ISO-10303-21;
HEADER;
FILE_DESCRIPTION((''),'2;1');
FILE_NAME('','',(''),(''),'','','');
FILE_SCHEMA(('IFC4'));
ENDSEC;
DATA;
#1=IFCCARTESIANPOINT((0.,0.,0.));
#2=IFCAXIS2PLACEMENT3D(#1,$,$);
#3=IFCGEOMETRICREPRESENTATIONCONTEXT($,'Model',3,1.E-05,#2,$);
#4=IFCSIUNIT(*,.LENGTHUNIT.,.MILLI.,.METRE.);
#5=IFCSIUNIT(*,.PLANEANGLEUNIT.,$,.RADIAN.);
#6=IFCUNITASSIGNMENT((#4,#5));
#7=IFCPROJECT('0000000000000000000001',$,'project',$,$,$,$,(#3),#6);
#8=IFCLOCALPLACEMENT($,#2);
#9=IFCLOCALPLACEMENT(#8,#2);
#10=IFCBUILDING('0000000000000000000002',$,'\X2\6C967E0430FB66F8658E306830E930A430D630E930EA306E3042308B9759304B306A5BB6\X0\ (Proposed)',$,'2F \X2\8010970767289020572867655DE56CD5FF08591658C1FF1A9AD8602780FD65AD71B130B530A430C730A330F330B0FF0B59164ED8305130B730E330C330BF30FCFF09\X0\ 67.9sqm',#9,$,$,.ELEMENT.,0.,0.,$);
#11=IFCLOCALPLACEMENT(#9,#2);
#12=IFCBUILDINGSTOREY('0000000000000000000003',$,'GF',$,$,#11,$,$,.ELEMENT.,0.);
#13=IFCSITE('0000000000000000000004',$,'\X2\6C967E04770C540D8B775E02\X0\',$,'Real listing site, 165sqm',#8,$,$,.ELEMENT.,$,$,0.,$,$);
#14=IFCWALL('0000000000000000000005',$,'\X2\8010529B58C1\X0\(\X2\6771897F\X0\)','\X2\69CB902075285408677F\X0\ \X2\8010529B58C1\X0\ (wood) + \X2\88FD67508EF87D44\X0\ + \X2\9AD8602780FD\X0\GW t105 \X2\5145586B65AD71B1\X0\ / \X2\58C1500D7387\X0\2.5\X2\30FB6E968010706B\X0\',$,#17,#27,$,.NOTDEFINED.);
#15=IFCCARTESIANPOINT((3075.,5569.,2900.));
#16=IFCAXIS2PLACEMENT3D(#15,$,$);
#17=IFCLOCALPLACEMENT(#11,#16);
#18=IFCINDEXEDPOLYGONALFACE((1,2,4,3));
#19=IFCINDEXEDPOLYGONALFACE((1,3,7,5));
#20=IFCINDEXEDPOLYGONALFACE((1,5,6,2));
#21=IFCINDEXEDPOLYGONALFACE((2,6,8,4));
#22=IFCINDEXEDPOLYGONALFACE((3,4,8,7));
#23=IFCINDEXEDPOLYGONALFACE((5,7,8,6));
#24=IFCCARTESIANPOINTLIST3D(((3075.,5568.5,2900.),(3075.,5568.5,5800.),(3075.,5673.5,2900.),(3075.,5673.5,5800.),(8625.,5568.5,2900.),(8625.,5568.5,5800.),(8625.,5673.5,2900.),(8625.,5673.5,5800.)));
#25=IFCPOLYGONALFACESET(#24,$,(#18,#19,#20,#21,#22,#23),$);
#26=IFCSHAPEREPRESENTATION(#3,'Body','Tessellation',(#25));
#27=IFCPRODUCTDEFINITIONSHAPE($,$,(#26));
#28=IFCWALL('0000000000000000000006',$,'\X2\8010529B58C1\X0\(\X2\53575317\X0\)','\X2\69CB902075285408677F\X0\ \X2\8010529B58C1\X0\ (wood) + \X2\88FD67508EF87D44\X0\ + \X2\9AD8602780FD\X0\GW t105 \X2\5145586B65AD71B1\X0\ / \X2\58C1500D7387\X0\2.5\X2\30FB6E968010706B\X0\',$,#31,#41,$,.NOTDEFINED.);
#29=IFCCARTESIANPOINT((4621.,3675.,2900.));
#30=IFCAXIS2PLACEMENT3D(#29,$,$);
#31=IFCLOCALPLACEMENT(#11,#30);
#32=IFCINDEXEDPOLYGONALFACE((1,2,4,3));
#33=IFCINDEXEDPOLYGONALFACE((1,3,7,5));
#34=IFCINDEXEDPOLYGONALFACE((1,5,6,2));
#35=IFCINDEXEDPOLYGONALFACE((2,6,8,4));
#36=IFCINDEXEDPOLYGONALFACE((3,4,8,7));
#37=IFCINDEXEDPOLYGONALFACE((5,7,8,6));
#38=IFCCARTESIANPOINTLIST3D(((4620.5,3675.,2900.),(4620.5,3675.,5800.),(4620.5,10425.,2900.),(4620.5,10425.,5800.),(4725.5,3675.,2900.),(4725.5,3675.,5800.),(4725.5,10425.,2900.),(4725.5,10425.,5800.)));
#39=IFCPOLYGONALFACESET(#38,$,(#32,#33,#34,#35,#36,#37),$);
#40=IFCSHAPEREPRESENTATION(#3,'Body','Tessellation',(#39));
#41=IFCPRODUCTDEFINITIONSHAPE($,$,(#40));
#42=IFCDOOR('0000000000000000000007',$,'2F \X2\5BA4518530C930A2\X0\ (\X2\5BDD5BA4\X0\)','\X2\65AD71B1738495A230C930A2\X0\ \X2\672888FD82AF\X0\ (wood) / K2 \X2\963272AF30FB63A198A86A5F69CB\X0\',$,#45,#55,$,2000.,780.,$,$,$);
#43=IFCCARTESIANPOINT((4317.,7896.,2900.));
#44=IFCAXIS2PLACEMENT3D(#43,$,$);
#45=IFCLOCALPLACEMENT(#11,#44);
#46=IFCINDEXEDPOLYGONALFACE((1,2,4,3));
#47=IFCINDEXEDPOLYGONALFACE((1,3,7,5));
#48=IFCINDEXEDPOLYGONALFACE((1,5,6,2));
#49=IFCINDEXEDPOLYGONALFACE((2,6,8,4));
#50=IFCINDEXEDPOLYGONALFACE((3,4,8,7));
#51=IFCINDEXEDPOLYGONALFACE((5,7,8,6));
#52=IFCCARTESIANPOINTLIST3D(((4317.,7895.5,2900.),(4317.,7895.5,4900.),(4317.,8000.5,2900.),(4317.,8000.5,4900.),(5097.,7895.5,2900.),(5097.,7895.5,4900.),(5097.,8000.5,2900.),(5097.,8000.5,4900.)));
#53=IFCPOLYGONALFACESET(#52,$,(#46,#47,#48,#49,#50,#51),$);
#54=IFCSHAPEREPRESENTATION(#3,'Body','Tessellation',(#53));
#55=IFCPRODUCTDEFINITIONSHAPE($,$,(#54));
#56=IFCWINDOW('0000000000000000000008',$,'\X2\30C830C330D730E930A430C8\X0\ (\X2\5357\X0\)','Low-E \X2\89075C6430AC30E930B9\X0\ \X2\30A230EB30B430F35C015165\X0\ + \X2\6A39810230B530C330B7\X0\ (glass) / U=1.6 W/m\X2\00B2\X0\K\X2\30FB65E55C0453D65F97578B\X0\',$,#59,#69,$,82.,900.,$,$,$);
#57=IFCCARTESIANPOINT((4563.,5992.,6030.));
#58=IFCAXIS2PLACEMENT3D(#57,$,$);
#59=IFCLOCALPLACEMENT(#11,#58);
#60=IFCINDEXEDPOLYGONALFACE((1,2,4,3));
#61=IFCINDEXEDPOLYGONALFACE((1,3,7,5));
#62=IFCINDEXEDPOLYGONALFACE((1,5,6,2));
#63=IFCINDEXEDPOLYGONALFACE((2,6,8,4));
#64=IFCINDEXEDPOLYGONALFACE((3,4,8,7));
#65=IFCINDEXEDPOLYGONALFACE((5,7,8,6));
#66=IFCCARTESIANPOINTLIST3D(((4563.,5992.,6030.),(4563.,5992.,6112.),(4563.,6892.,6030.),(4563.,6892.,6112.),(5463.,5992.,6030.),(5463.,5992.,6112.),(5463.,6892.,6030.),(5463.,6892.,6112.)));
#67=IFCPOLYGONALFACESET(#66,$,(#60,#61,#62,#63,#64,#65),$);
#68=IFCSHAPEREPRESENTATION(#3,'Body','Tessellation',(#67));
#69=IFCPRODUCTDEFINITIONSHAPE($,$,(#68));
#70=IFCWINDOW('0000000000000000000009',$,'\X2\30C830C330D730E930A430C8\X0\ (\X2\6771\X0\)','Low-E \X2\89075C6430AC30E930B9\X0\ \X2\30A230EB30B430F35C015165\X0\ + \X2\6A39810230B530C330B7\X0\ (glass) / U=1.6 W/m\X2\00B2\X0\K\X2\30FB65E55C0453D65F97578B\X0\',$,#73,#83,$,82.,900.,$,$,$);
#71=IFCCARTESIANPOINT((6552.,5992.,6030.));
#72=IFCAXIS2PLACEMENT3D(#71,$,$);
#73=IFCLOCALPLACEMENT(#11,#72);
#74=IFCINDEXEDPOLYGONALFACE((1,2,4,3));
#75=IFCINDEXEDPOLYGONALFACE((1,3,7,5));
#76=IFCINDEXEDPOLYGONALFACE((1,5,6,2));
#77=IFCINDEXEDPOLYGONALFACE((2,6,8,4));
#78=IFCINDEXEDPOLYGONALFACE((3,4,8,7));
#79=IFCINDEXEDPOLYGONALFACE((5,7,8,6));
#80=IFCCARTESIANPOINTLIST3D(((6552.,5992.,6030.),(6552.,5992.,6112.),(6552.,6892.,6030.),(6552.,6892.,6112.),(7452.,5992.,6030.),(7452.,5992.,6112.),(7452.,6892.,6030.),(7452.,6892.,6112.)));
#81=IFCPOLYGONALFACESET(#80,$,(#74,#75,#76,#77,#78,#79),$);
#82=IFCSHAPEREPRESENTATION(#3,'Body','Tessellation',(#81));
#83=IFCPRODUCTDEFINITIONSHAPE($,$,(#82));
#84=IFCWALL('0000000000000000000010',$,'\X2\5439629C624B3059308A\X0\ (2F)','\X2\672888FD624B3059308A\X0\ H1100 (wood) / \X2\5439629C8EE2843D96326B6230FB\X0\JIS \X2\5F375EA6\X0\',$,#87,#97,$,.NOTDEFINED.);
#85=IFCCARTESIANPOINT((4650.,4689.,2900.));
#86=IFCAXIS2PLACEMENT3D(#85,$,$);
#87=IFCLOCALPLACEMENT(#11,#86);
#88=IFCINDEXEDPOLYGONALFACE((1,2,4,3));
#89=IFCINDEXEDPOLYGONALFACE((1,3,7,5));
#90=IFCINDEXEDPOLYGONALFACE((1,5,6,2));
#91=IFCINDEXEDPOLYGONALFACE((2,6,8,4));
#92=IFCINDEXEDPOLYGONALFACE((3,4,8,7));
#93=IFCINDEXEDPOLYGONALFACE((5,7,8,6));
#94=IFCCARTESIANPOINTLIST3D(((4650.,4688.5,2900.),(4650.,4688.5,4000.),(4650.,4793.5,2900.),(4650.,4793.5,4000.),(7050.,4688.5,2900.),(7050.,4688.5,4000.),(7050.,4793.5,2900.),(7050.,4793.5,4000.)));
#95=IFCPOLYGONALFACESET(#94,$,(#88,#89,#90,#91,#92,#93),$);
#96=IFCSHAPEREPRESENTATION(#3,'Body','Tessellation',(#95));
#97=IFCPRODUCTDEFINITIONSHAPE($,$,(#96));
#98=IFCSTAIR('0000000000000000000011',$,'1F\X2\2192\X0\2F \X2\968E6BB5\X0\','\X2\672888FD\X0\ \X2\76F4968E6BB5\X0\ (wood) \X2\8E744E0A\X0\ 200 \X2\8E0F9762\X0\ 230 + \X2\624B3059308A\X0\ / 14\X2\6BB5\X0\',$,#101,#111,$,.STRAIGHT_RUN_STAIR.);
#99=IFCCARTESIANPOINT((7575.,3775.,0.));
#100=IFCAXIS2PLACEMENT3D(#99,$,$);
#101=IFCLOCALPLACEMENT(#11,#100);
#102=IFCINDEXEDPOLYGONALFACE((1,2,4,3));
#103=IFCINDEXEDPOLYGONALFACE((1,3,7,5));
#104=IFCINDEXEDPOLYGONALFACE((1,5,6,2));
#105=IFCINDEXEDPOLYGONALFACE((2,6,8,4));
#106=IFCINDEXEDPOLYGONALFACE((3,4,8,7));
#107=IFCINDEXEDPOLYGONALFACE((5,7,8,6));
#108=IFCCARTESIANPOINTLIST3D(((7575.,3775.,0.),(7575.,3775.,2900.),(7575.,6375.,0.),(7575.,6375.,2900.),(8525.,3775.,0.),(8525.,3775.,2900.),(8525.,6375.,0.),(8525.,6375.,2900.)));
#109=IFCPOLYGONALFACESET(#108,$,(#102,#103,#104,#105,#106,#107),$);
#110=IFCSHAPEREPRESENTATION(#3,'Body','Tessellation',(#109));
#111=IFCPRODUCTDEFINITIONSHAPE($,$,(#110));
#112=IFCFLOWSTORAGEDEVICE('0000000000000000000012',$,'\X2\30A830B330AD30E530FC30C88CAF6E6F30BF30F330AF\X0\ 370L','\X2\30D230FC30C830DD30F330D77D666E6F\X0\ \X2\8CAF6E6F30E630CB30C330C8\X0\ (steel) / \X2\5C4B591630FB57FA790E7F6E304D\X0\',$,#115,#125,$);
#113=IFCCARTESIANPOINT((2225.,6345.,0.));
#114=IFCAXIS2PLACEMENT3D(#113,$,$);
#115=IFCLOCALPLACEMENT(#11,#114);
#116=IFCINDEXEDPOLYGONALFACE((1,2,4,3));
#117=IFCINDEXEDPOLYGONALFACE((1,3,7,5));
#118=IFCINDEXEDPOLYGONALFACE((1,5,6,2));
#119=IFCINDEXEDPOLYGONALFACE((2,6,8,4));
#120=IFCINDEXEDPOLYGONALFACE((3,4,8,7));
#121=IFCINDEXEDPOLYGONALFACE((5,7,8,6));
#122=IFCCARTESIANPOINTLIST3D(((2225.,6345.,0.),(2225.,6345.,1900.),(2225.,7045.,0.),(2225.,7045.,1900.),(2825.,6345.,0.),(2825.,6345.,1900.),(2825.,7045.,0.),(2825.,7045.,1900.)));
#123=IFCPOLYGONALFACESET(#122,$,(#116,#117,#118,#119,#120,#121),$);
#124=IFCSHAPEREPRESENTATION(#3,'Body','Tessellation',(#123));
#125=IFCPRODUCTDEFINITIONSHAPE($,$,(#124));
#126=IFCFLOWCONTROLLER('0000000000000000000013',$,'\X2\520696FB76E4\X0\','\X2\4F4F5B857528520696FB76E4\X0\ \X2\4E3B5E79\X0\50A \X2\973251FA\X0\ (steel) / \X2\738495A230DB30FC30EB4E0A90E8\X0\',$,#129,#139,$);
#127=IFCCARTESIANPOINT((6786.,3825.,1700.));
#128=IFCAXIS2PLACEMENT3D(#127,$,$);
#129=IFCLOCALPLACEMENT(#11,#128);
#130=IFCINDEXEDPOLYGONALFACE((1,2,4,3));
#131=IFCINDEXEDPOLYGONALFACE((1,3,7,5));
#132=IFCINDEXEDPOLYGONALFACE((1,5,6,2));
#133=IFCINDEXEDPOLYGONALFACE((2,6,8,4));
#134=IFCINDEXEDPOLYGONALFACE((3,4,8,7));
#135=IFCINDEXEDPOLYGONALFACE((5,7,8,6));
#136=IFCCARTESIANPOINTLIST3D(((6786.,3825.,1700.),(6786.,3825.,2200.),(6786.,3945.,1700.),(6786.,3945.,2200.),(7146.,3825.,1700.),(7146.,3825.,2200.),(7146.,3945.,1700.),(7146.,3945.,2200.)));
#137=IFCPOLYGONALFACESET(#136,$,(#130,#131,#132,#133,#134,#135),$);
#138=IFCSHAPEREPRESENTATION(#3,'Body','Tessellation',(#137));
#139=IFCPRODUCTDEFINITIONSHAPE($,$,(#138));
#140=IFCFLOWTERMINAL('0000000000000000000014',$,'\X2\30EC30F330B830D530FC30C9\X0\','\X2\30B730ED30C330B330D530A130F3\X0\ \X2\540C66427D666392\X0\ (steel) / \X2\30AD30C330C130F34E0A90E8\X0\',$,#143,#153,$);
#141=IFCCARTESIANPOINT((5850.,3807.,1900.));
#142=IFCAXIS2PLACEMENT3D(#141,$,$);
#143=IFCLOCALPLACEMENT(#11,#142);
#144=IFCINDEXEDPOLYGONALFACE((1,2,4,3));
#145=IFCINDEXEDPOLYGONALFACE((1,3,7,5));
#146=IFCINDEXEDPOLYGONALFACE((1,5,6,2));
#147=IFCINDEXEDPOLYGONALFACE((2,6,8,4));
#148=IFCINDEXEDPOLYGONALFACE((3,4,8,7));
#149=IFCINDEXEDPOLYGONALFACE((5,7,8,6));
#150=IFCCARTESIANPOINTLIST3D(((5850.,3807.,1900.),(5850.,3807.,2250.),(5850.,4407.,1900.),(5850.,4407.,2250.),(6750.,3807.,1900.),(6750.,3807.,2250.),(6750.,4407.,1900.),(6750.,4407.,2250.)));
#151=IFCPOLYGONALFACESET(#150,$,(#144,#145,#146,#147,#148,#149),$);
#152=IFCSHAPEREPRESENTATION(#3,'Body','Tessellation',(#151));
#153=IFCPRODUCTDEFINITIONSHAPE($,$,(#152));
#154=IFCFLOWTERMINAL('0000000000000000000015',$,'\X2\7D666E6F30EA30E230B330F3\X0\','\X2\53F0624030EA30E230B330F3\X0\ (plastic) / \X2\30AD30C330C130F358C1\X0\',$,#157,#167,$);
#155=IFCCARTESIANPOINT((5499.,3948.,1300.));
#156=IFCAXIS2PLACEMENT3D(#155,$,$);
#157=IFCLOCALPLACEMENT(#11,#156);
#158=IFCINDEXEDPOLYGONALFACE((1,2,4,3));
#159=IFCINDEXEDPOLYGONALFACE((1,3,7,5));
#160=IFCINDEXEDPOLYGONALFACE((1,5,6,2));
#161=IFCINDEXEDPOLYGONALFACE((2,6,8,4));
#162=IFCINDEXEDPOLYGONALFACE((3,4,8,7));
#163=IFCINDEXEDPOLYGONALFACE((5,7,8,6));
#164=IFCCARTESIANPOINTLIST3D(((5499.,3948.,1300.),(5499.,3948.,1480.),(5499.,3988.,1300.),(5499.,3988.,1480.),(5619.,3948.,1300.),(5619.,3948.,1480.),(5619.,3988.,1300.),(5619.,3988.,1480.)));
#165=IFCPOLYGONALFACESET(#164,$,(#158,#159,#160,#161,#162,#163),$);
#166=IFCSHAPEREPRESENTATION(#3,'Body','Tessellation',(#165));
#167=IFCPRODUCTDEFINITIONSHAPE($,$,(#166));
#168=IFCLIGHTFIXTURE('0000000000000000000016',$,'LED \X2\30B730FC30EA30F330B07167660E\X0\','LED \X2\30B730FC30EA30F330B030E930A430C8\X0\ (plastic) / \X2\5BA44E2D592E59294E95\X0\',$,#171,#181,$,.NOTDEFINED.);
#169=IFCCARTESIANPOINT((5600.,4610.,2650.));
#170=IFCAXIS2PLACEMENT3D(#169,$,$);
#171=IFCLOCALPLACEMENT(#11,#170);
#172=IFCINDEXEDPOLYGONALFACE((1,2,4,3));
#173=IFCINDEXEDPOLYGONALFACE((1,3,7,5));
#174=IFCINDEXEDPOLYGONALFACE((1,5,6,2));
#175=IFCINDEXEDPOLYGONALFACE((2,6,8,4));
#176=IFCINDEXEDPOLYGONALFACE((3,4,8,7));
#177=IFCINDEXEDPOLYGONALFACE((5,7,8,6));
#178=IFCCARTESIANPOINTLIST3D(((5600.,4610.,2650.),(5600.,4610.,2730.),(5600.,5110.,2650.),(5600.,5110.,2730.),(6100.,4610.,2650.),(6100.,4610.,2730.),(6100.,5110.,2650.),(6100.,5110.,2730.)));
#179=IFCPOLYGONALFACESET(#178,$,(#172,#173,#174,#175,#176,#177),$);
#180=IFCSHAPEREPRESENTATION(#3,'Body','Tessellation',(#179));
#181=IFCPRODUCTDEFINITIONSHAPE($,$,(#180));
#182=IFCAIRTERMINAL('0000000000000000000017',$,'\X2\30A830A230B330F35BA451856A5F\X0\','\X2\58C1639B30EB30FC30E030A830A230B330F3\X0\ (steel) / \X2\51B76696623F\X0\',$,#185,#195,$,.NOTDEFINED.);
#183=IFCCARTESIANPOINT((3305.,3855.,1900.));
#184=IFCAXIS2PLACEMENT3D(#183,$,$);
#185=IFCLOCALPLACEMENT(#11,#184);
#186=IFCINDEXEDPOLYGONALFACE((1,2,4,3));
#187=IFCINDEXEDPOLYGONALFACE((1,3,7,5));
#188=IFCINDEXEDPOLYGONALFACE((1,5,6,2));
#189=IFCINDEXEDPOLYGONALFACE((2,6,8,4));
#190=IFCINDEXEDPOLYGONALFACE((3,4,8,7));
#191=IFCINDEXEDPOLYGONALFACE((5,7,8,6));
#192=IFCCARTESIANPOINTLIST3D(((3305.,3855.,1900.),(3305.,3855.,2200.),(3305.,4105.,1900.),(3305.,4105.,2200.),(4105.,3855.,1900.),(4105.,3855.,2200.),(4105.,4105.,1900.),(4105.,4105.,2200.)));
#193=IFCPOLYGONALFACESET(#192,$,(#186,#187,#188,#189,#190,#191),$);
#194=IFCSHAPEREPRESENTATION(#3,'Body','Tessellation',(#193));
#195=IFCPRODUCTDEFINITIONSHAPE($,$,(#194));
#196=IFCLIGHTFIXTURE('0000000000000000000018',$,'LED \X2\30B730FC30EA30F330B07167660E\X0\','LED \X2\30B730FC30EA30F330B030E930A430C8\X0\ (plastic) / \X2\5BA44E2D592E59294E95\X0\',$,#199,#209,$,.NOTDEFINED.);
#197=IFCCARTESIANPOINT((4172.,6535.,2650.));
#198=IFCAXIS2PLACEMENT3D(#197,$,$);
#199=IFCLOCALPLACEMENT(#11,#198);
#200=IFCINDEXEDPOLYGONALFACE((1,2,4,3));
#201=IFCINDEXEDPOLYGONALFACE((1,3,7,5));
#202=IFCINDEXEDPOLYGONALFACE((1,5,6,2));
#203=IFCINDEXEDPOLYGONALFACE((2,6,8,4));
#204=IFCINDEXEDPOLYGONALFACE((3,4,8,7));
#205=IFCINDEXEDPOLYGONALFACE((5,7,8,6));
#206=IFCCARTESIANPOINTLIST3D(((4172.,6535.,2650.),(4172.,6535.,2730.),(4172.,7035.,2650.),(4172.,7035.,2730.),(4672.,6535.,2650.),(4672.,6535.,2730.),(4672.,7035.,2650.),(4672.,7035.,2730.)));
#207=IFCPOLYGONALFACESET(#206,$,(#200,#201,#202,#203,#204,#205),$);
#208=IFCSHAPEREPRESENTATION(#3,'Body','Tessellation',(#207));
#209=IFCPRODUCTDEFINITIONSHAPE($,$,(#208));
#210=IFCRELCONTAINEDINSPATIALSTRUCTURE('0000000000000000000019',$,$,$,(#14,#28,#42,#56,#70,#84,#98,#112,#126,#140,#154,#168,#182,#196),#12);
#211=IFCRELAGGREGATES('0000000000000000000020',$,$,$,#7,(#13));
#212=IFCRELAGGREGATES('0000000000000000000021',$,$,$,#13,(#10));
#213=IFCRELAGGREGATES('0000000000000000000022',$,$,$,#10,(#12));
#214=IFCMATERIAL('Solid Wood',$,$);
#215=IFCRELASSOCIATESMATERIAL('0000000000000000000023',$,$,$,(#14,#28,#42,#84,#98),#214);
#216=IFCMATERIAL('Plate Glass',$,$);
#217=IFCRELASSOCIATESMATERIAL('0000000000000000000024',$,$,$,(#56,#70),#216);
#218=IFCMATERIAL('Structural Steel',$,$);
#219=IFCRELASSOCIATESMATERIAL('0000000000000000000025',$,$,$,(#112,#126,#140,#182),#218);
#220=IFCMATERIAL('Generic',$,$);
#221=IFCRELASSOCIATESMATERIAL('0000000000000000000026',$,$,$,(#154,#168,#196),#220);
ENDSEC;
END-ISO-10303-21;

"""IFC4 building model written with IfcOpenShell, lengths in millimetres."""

from ifc_helpers import new_model, si_unit, frame, frame_2d, origin, place, context, project, spatial, rectangle, extrude, material, element, fill, save


model = new_model("IFC4")

# Units and contexts
model_context = context("Model", 3, precision=1e-05, world=origin())
ifc_project = project(units=[si_unit("LENGTHUNIT", "METRE", prefix="MILLI"), si_unit("PLANEANGLEUNIT", "RADIAN")], contexts=[model_context])

# Site, building, storey
site_placement = place(None, origin())
site = spatial("IfcSite", under=ifc_project, at=site_placement, Name="沖縄県名護市", ObjectType="Real listing site, 165sqm", CompositionType="ELEMENT", RefElevation=0.0)
building_placement = place(site_placement, origin())
building = spatial("IfcBuilding", under=site, at=building_placement, Name="沖縄・書斎とライブラリのある静かな家 (Proposed)", ObjectType="2F 耐震木造在来工法（外壁：高性能断熱サイディング＋外付けシャッター） 67.9sqm", CompositionType="ELEMENT", ElevationOfRefHeight=0.0, ElevationOfTerrain=0.0)
storey_placement = place(building_placement, origin())
storey = spatial("IfcBuildingStorey", under=building, at=storey_placement, Name="GF", CompositionType="ELEMENT", Elevation=0.0)

# Shared definitions
ifc_material_1 = material(Name="Solid Wood")

# Wall
wall_1_placement = place(storey_placement, frame((3075.0, 5569.0, 2900.0)))
element("IfcWall", 1, at=wall_1_placement, inside=storey, material=ifc_material_1, Name="耐力壁(東西)", Description="構造用合板 耐力壁 (wood) + 製材軸組 + 高性能GW t105 充填断熱 / 壁倍率2.5・準耐火", PredefinedType="NOTDEFINED", context=model_context, shape_type="SweptSolid", body=[
    extrude(rectangle(XDim=5550.0, YDim=105.0, at=frame_2d((2775.0, 52.0))), frame((3075.0, 5569.0, 2900.0)), (0.0, 0.0, 1.0), 2900.0),
])

# Wall, opening, door
wall_2_placement = place(storey_placement, frame((4621.0, 3675.0, 2900.0)))
wall_2 = element("IfcWall", 2, at=wall_2_placement, inside=storey, material=ifc_material_1, Name="耐力壁(南北)", Description="構造用合板 耐力壁 (wood) + 製材軸組 + 高性能GW t105 充填断熱 / 壁倍率2.5・準耐火", PredefinedType="NOTDEFINED", context=model_context, shape_type="SweptSolid", body=[
    extrude(rectangle(XDim=105.0, YDim=6750.0, at=frame_2d((52.0, 3375.0))), frame((4621.0, 3675.0, 2900.0)), (0.0, 0.0, 1.0), 2900.0),
])
opening_placement = place(storey_placement, frame((4317.0, 7896.0, 2900.0)))
opening = element("IfcOpeningElement", 3, at=opening_placement, cuts=wall_2, PredefinedType="NOTDEFINED", context=model_context, shape_type="SweptSolid", body=[
    extrude(rectangle(XDim=780.0, YDim=105.0, at=frame_2d((390.0, 52.0))), frame((4317.0, 7896.0, 2900.0)), (0.0, 0.0, 1.0), 2000.0),
])
door_placement = place(storey_placement, frame((4317.0, 7896.0, 2900.0)))
door = element("IfcDoor", 4, at=door_placement, inside=storey, material=ifc_material_1, Name="2F 室内ドア (寝室)", Description="断熱玄関ドア 木製芯 (wood) / K2 防犯・採風機構", OverallHeight=2000.0, OverallWidth=780.0, context=model_context, shape_type="SweptSolid", body=[
    extrude(rectangle(XDim=780.0, YDim=105.0, at=frame_2d((390.0, 52.0))), frame((4317.0, 7896.0, 2900.0)), (0.0, 0.0, 1.0), 2000.0),
])
fill(opening, door)

# Windows
ifc_material_2 = material(Name="Plate Glass")
window_1_placement = place(storey_placement, frame((4563.0, 5992.0, 6030.0)))
element("IfcWindow", 5, at=window_1_placement, inside=storey, material=ifc_material_2, Name="トップライト (南)", Description="Low-E 複層ガラス アルゴン封入 + 樹脂サッシ (glass) / U=1.6 W/m²K・日射取得型", OverallHeight=82.0, OverallWidth=900.0, context=model_context, shape_type="SweptSolid", body=[
    extrude(rectangle(XDim=900.0, YDim=900.0, at=frame_2d((450.0, 450.0))), frame((4563.0, 5992.0, 6030.0)), (0.0, 0.0, 1.0), 82.0),
])
window_2_placement = place(storey_placement, frame((6552.0, 5992.0, 6030.0)))
element("IfcWindow", 6, at=window_2_placement, inside=storey, material=ifc_material_2, Name="トップライト (東)", Description="Low-E 複層ガラス アルゴン封入 + 樹脂サッシ (glass) / U=1.6 W/m²K・日射取得型", OverallHeight=82.0, OverallWidth=900.0, context=model_context, shape_type="SweptSolid", body=[
    extrude(rectangle(XDim=900.0, YDim=900.0, at=frame_2d((450.0, 450.0))), frame((6552.0, 5992.0, 6030.0)), (0.0, 0.0, 1.0), 82.0),
])

# Wall
wall_3_placement = place(storey_placement, frame((4650.0, 4689.0, 2900.0)))
element("IfcWall", 7, at=wall_3_placement, inside=storey, material=ifc_material_1, Name="吹抜手すり (2F)", Description="木製手すり H1100 (wood) / 吹抜転落防止・JIS 強度", PredefinedType="NOTDEFINED", context=model_context, shape_type="SweptSolid", body=[
    extrude(rectangle(XDim=2400.0, YDim=105.0, at=frame_2d((1200.0, 52.0))), frame((4650.0, 4689.0, 2900.0)), (0.0, 0.0, 1.0), 1100.0),
])

# Stair
stair_placement = place(storey_placement, frame((7575.0, 3775.0, 0.0)))
element("IfcStair", 8, at=stair_placement, inside=storey, material=ifc_material_1, Name="1F→2F 階段", Description="木製 直階段 (wood) 蹴上 200 踏面 230 + 手すり / 14段", PredefinedType="STRAIGHT_RUN_STAIR", context=model_context, shape_type="SweptSolid", body=[
    extrude(rectangle(XDim=950.0, YDim=2600.0, at=frame_2d((475.0, 1300.0))), frame((7575.0, 3775.0, 0.0)), (0.0, 0.0, 1.0), 2900.0),
])

# Flow storage device
ifc_material_3 = material(Name="Structural Steel")
flow_storage_device_placement = place(storey_placement, frame((2225.0, 6345.0, 0.0)))
element("IfcFlowStorageDevice", 9, at=flow_storage_device_placement, inside=storey, material=ifc_material_3, Name="エコキュート貯湯タンク 370L", Description="ヒートポンプ給湯 貯湯ユニット (steel) / 屋外・基礎置き", context=model_context, shape_type="SweptSolid", body=[
    extrude(rectangle(XDim=600.0, YDim=700.0, at=frame_2d((300.0, 350.0))), frame((2225.0, 6345.0, 0.0)), (0.0, 0.0, 1.0), 1900.0),
])

# Flow controller
flow_controller_placement = place(storey_placement, frame((6786.0, 3825.0, 1700.0)))
element("IfcFlowController", 10, at=flow_controller_placement, inside=storey, material=ifc_material_3, Name="分電盤", Description="住宅用分電盤 主幹50A 露出 (steel) / 玄関ホール上部", context=model_context, shape_type="SweptSolid", body=[
    extrude(rectangle(XDim=360.0, YDim=120.0, at=frame_2d((180.0, 60.0))), frame((6786.0, 3825.0, 1700.0)), (0.0, 0.0, 1.0), 500.0),
])

# Flow terminals
flow_terminal_1_placement = place(storey_placement, frame((5850.0, 3807.0, 1900.0)))
element("IfcFlowTerminal", 11, at=flow_terminal_1_placement, inside=storey, material=ifc_material_3, Name="レンジフード", Description="シロッコファン 同時給排 (steel) / キッチン上部", context=model_context, shape_type="SweptSolid", body=[
    extrude(rectangle(XDim=900.0, YDim=600.0, at=frame_2d((450.0, 300.0))), frame((5850.0, 3807.0, 1900.0)), (0.0, 0.0, 1.0), 350.0),
])
ifc_material_4 = material(Name="Generic")
flow_terminal_2_placement = place(storey_placement, frame((5499.0, 3948.0, 1300.0)))
element("IfcFlowTerminal", 12, at=flow_terminal_2_placement, inside=storey, material=ifc_material_4, Name="給湯リモコン", Description="台所リモコン (plastic) / キッチン壁", context=model_context, shape_type="SweptSolid", body=[
    extrude(rectangle(XDim=120.0, YDim=40.0, at=frame_2d((60.0, 20.0))), frame((5499.0, 3948.0, 1300.0)), (0.0, 0.0, 1.0), 180.0),
])

# Light fixture
light_fixture_1_placement = place(storey_placement, frame((5600.0, 4610.0, 2650.0)))
element("IfcLightFixture", 13, at=light_fixture_1_placement, inside=storey, material=ifc_material_4, Name="LED シーリング照明", Description="LED シーリングライト (plastic) / 室中央天井", PredefinedType="NOTDEFINED", context=model_context, shape_type="SweptSolid", body=[
    extrude(rectangle(XDim=500.0, YDim=500.0, at=frame_2d((250.0, 250.0))), frame((5600.0, 4610.0, 2650.0)), (0.0, 0.0, 1.0), 80.0),
])

# Air terminal
air_terminal_1_placement = place(storey_placement, frame((3305.0, 3855.0, 1900.0)))
element("IfcAirTerminal", 14, at=air_terminal_1_placement, inside=storey, material=ifc_material_3, Name="エアコン室内機", Description="壁掛ルームエアコン (steel) / 冷暖房", PredefinedType="NOTDEFINED", context=model_context, shape_type="SweptSolid", body=[
    extrude(rectangle(XDim=800.0, YDim=250.0, at=frame_2d((400.0, 125.0))), frame((3305.0, 3855.0, 1900.0)), (0.0, 0.0, 1.0), 300.0),
])

# Light fixture
light_fixture_2_placement = place(storey_placement, frame((4172.0, 6535.0, 2650.0)))
element("IfcLightFixture", 15, at=light_fixture_2_placement, inside=storey, material=ifc_material_4, Name="LED シーリング照明", Description="LED シーリングライト (plastic) / 室中央天井", PredefinedType="NOTDEFINED", context=model_context, shape_type="SweptSolid", body=[
    extrude(rectangle(XDim=500.0, YDim=500.0, at=frame_2d((250.0, 250.0))), frame((4172.0, 6535.0, 2650.0)), (0.0, 0.0, 1.0), 80.0),
])

save(model, "model.ifc")
